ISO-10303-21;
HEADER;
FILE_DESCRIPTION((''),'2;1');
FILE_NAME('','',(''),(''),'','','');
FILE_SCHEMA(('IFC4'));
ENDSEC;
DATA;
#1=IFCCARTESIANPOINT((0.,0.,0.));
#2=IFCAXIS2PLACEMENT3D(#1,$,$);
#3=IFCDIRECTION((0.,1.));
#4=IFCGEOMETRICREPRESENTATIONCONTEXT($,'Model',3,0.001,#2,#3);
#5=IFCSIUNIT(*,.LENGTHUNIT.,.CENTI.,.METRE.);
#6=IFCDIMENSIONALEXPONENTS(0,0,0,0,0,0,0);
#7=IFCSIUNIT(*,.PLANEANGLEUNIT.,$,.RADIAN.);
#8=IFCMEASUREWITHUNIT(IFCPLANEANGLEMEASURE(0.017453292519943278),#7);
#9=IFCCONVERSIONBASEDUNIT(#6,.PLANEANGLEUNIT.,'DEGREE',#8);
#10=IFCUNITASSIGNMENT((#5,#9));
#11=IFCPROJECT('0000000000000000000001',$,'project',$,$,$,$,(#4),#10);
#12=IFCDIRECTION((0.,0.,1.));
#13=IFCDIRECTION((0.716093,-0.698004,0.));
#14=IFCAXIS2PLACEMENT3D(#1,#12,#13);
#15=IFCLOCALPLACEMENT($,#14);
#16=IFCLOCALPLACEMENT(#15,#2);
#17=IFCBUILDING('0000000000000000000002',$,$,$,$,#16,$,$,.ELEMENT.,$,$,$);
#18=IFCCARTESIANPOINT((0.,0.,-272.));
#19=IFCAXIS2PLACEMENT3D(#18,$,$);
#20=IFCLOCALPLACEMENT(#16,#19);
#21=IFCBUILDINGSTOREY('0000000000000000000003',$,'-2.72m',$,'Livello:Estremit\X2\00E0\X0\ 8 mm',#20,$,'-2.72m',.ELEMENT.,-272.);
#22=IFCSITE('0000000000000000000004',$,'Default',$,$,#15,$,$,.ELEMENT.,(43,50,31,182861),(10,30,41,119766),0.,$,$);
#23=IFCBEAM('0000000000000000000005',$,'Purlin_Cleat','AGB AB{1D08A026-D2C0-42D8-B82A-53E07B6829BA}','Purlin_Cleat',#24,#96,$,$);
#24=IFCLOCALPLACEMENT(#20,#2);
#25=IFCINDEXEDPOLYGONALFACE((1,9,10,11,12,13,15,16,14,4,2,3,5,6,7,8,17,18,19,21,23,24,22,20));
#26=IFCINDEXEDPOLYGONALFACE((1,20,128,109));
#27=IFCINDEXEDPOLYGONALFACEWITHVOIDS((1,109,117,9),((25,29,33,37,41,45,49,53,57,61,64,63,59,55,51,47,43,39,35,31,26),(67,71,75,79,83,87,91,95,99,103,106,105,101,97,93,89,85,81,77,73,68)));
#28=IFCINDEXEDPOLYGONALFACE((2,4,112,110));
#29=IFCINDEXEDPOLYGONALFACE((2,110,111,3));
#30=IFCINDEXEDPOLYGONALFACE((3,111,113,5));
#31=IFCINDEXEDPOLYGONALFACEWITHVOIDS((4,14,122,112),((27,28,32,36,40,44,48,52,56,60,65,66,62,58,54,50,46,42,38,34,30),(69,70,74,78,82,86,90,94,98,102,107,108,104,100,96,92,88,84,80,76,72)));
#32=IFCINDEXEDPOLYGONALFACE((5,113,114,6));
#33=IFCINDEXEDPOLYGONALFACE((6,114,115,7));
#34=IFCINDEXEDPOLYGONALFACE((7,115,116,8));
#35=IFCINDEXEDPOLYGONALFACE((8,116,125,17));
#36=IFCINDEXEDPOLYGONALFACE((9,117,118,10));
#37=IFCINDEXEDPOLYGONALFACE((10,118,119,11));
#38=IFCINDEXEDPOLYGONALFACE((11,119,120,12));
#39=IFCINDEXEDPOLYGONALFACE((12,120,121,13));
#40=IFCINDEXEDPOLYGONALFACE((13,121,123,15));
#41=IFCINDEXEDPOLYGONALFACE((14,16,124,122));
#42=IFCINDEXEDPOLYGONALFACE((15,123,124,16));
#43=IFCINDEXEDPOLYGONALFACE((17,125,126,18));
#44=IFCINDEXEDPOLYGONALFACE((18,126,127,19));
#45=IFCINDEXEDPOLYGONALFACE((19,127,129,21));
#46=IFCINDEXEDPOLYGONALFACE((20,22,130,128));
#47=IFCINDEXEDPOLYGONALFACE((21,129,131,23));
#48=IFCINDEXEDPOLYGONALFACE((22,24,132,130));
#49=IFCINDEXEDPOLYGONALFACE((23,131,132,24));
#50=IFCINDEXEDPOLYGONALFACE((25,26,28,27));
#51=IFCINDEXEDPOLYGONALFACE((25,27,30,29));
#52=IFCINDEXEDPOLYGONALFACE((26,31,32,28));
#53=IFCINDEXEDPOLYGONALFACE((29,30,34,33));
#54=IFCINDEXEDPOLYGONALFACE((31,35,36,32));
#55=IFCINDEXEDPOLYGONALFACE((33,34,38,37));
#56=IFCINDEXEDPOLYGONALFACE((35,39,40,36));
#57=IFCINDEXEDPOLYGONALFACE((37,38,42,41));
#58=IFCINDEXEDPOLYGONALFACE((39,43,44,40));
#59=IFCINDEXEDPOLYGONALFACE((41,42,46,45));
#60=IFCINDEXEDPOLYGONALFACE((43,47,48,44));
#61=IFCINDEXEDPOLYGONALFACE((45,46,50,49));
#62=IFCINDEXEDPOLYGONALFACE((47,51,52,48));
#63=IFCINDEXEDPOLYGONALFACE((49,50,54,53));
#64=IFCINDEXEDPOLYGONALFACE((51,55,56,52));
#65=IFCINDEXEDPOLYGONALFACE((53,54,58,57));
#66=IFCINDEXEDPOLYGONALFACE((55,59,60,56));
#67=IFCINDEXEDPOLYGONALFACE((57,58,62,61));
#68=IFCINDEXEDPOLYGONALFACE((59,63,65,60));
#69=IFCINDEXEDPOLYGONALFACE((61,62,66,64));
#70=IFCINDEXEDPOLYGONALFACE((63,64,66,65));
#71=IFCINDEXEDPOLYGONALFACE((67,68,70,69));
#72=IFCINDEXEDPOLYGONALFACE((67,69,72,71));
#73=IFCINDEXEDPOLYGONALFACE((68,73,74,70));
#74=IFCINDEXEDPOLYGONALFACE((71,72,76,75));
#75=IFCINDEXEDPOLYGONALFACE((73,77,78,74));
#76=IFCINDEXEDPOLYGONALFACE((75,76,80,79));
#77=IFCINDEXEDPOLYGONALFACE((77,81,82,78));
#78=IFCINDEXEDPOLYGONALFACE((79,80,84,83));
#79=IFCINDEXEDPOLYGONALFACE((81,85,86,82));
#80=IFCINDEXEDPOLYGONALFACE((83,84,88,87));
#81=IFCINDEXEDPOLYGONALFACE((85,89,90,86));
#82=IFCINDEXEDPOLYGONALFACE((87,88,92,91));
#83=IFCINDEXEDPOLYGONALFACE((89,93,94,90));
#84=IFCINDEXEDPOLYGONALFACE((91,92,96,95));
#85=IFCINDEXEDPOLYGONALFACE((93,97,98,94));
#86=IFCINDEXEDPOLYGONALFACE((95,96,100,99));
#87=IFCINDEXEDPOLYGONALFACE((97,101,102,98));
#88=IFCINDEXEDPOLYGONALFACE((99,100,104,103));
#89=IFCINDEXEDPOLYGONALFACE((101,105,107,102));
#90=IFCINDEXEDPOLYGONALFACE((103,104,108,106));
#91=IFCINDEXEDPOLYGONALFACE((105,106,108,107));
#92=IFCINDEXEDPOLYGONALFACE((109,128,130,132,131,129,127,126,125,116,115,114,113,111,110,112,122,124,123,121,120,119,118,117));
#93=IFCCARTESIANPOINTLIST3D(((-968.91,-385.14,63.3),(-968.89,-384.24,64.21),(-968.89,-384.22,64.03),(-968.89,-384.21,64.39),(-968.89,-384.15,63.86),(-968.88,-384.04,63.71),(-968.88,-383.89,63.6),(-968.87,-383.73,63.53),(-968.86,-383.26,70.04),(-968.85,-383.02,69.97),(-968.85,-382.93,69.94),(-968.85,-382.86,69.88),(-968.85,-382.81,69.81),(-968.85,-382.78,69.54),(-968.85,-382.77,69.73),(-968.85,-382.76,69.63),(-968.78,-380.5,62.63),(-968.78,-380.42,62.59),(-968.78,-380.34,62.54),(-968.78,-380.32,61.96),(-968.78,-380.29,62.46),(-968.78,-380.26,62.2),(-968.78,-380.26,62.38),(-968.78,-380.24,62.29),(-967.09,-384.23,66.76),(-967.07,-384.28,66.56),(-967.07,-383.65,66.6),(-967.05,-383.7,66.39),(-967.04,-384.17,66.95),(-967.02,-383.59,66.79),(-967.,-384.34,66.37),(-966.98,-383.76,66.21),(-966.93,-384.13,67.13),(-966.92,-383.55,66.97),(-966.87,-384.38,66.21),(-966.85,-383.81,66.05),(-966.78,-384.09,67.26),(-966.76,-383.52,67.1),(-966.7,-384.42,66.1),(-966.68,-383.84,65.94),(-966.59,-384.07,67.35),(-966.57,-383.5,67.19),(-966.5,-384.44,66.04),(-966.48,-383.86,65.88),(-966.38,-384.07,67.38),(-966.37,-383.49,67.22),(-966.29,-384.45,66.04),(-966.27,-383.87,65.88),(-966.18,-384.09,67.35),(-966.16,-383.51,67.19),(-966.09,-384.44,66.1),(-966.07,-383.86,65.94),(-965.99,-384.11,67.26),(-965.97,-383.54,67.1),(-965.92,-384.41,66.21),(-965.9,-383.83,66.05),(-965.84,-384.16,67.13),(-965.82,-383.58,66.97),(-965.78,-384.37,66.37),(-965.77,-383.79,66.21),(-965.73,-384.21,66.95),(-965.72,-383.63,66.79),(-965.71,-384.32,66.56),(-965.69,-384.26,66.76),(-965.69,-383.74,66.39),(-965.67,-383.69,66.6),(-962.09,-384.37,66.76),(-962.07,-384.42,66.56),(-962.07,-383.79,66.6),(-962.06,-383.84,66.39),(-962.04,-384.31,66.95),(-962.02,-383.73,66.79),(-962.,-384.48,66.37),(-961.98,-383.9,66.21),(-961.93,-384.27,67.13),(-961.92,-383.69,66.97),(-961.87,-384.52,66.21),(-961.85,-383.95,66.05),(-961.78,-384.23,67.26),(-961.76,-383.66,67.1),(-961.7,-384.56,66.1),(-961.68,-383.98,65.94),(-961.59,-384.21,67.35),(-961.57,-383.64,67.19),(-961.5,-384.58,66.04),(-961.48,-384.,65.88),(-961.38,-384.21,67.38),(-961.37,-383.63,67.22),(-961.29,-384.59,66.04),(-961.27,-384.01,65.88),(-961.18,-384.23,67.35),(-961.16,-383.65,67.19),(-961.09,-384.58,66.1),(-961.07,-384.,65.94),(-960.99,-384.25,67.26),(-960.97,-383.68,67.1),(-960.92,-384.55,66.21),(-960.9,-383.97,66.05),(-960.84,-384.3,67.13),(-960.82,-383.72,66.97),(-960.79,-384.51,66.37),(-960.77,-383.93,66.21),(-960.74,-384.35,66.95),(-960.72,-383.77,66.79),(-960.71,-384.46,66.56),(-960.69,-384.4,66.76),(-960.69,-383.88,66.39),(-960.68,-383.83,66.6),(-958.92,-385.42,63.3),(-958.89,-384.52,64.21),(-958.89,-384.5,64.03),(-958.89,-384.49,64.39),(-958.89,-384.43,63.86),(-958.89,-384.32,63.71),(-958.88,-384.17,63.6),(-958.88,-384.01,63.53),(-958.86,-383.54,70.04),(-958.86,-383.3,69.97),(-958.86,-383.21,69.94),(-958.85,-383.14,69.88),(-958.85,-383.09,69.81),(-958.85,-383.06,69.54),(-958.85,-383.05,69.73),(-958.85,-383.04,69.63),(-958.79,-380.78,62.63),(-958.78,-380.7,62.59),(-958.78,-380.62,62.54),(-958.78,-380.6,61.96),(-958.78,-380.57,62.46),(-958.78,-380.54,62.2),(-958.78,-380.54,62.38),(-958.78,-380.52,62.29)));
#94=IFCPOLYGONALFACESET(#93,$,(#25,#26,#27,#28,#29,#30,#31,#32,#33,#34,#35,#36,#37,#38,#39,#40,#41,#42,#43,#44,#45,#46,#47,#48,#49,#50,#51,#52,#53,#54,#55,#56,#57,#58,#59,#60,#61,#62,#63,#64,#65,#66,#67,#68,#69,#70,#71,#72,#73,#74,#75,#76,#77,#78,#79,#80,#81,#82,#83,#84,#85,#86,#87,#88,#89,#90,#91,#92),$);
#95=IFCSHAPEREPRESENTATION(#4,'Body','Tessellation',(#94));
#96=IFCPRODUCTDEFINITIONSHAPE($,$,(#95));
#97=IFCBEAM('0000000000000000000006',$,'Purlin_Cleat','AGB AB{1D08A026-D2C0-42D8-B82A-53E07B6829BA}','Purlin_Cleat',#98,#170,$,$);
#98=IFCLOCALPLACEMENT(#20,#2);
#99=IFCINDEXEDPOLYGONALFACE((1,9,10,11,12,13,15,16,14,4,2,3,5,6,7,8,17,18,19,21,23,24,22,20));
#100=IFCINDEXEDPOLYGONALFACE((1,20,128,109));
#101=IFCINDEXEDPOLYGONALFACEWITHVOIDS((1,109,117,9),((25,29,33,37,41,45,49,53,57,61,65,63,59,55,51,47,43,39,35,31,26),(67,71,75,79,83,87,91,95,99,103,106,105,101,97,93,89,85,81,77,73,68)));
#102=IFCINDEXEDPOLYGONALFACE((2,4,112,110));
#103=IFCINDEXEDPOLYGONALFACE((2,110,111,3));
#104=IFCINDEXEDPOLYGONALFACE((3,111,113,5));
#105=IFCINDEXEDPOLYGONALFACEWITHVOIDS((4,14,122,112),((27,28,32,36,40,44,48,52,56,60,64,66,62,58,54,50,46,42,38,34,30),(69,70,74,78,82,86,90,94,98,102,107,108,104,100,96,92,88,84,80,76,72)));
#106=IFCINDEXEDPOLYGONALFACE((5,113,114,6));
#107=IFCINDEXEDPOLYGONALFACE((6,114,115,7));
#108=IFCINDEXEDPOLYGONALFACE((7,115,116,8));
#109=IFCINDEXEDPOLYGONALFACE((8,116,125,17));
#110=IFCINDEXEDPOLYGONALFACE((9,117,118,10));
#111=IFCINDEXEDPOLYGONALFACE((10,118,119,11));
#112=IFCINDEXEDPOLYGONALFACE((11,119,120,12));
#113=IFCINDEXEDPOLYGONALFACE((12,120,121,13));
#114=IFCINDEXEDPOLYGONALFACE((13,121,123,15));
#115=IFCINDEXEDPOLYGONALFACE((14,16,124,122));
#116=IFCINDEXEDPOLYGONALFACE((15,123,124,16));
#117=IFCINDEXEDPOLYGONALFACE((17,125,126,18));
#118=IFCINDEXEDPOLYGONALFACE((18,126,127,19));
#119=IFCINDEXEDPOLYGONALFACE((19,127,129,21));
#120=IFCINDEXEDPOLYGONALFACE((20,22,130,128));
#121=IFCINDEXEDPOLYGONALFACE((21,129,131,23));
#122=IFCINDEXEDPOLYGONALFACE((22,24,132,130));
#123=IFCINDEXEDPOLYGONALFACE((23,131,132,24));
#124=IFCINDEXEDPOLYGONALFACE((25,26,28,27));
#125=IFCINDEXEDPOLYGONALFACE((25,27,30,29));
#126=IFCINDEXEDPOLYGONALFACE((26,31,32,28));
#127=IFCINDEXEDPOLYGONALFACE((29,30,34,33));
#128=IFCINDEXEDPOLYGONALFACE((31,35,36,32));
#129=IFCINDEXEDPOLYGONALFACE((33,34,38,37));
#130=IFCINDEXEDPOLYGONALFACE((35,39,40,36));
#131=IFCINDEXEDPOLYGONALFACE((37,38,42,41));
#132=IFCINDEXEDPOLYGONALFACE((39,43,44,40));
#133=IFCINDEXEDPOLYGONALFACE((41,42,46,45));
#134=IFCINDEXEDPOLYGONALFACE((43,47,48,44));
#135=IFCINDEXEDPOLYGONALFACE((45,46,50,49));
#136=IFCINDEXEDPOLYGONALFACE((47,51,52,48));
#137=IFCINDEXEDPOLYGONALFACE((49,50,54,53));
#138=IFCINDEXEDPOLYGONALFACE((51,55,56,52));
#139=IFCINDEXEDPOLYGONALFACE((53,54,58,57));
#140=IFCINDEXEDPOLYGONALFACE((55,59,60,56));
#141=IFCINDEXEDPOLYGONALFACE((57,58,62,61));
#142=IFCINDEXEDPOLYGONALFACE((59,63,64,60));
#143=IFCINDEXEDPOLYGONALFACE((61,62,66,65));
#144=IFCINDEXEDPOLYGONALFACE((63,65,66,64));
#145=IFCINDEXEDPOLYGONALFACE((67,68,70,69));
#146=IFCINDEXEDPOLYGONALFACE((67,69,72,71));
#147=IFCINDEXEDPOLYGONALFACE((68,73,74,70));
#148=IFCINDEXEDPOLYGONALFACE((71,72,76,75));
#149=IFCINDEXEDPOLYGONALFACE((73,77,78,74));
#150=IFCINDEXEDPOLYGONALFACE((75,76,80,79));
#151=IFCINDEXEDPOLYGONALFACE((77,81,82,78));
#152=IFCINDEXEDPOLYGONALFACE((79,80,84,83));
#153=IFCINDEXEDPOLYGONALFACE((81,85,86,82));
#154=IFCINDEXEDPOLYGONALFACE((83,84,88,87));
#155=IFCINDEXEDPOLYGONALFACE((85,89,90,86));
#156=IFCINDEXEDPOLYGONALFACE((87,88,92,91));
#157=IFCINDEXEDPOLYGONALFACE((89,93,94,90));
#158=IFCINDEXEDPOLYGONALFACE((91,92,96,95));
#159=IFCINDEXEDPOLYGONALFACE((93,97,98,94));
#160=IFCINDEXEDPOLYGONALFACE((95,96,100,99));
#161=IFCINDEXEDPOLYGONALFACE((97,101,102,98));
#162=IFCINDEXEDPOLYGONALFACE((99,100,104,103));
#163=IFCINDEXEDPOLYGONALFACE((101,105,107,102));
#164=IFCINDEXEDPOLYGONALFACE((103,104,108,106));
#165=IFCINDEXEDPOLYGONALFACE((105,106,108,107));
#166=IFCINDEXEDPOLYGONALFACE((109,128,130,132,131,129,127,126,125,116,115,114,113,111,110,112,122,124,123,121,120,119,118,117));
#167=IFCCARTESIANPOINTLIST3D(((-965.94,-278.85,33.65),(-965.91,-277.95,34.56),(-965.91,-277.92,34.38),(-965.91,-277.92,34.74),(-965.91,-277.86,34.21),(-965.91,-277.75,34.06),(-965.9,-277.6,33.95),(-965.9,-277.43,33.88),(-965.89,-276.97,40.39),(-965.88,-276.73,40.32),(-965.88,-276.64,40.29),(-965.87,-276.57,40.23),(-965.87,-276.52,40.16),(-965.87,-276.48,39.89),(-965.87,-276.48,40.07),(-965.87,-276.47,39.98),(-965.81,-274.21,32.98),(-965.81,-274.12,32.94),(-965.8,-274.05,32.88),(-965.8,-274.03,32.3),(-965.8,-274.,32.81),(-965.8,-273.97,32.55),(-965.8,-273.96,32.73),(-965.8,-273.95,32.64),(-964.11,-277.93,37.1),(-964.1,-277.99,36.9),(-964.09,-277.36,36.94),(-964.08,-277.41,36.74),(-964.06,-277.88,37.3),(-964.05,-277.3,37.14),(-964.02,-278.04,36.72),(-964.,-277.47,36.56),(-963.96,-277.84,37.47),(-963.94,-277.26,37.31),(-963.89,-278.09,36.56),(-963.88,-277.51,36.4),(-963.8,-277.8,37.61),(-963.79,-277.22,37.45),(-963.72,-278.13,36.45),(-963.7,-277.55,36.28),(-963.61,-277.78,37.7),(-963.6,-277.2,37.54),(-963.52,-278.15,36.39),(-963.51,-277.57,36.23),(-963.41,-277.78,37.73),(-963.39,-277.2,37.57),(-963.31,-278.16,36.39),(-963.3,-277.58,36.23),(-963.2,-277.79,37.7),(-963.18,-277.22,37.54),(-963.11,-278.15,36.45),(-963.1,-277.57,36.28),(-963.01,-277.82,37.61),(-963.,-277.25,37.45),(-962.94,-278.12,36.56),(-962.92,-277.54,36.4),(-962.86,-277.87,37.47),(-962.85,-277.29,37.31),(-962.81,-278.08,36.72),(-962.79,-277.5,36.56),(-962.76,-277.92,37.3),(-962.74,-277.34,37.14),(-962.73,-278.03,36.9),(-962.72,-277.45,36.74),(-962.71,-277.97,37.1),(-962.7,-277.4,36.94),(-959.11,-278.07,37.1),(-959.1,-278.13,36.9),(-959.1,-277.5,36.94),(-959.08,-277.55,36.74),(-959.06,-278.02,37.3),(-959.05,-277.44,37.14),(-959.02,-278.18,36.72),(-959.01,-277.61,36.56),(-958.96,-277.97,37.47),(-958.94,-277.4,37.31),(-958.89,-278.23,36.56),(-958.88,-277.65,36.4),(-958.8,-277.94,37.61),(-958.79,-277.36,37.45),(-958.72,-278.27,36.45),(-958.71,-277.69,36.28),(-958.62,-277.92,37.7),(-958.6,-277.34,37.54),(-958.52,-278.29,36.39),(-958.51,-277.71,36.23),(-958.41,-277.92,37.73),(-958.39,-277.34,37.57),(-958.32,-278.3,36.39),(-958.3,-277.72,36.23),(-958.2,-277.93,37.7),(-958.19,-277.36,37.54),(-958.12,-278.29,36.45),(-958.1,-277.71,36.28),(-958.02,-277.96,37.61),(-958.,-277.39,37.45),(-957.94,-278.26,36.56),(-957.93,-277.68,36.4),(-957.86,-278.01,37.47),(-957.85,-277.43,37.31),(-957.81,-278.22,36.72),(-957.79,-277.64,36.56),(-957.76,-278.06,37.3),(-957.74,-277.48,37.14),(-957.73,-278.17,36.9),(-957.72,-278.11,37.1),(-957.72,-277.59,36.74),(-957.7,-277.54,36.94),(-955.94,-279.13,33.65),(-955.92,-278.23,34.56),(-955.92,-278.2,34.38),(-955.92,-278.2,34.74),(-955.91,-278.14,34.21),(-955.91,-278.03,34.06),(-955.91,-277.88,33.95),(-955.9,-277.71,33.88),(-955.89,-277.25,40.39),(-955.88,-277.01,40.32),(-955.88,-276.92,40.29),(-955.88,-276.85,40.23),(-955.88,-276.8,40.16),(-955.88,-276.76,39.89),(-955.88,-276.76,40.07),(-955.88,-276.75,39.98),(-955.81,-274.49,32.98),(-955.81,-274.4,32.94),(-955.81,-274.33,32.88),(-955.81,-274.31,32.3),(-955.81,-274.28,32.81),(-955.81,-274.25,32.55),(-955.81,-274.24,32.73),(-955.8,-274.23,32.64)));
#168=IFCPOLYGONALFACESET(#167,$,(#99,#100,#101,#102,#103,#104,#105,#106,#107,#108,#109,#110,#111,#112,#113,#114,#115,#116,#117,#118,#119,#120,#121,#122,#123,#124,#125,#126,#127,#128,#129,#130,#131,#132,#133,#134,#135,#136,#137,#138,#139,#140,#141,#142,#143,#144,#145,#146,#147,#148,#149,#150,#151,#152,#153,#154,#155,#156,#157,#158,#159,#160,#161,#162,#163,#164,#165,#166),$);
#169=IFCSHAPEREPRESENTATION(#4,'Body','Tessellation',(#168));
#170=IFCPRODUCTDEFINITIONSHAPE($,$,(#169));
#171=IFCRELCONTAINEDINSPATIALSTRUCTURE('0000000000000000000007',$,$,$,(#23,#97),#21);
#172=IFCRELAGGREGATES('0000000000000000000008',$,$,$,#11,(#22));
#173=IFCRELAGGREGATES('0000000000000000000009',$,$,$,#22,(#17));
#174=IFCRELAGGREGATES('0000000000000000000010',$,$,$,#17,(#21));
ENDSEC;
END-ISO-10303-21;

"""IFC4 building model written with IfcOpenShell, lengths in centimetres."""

from ifc_helpers import new_model, entity, si_unit, converted_unit, direction, frame, frame_2d, origin, place, context, project, spatial, circle, l_section, extrude, element, save


model = new_model("IFC4")

# Units and contexts
model_context = context("Model", 3, precision=0.001, world=origin(), true_north=direction((0.0, 1.0)))
ifc_project = project(units=[si_unit("LENGTHUNIT", "METRE", prefix="CENTI"), converted_unit("PLANEANGLEUNIT", "DEGREE", entity("IfcPlaneAngleMeasure", 0.017453292519943278), si_unit("PLANEANGLEUNIT", "RADIAN"), dimensions=[0, 0, 0, 0, 0, 0, 0])], contexts=[model_context])

# Site, building, storey
site_placement = place(None, frame((0.0, 0.0, 0.0), z_axis=(0.0, 0.0, 1.0), x_axis=(0.716093, -0.698004, 0.0)))
site = spatial("IfcSite", under=ifc_project, at=site_placement, Name="Default", CompositionType="ELEMENT", RefLatitude=(43, 50, 31, 182861), RefLongitude=(10, 30, 41, 119766), RefElevation=0.0)
building_placement = place(site_placement, origin())
building = spatial("IfcBuilding", under=site, at=building_placement, CompositionType="ELEMENT")
storey_placement = place(building_placement, frame((0.0, 0.0, -272.0)))
storey = spatial("IfcBuildingStorey", under=building, at=storey_placement, Name="-2.72m", ObjectType="Livello:Estremità 8 mm", LongName="-2.72m", CompositionType="ELEMENT", Elevation=-272.0)

# Beams, openings
beam_1_placement = place(storey_placement, frame((-958.87, -383.63, 65.14), z_axis=(-0.999608, 0.02798, 0.0), x_axis=(0.007515, 0.268478, 0.963256)))
beam_1 = element("IfcBeam", 1, at=beam_1_placement, inside=storey, Name="Purlin_Cleat", Description="AGB AB{1D08A026-D2C0-42D8-B82A-53E07B6829BA}", ObjectType="Purlin_Cleat", context=model_context, shape_type="SweptSolid", body=[
    extrude(l_section(Depth=5.0, Width=7.0, Thickness=0.6, FilletRadius=0.7, EdgeRadius=0.35, at=frame_2d((1.25, 1.27))), origin(), (0.0, 0.0, 1.0), 10.0),
])
opening_1_placement = place(beam_1_placement, frame((1.29, -1.3, 6.8), z_axis=(0.0, -1.0, 0.0), x_axis=(1.0, 0.0, 0.0)))
element("IfcOpeningElement", 2, at=opening_1_placement, cuts=beam_1, ObjectType="Opening", context=model_context, shape_type="SweptSolid", body=[
    extrude(circle(Radius=0.7, at=frame_2d((0.0, 0.7), x_axis=(1.0, 0.0))), origin(), (0.0, 0.0, -1.0), 0.7),
])
opening_2_placement = place(beam_1_placement, frame((1.29, -1.3, 1.8), z_axis=(0.0, -1.0, 0.0), x_axis=(1.0, 0.0, 0.0)))
element("IfcOpeningElement", 3, at=opening_2_placement, cuts=beam_1, ObjectType="Opening", context=model_context, shape_type="SweptSolid", body=[
    extrude(circle(Radius=0.7, at=frame_2d((0.0, 0.7), x_axis=(1.0, 0.0))), origin(), (0.0, 0.0, -1.0), 0.7),
])
beam_2_placement = place(storey_placement, frame((-955.89, -277.34, 35.48), z_axis=(-0.999608, 0.02798, 0.0), x_axis=(0.007515, 0.268478, 0.963256)))
beam_2 = element("IfcBeam", 4, at=beam_2_placement, inside=storey, Name="Purlin_Cleat", Description="AGB AB{1D08A026-D2C0-42D8-B82A-53E07B6829BA}", ObjectType="Purlin_Cleat", context=model_context, shape_type="SweptSolid", body=[
    extrude(l_section(Depth=5.0, Width=7.0, Thickness=0.6, FilletRadius=0.7, EdgeRadius=0.35, at=frame_2d((1.25, 1.27))), origin(), (0.0, 0.0, 1.0), 10.0),
])
opening_3_placement = place(beam_2_placement, frame((1.29, -1.3, 6.8), z_axis=(0.0, -1.0, 0.0), x_axis=(1.0, 0.0, 0.0)))
element("IfcOpeningElement", 5, at=opening_3_placement, cuts=beam_2, ObjectType="Opening", context=model_context, shape_type="SweptSolid", body=[
    extrude(circle(Radius=0.7, at=frame_2d((0.0, 0.7), x_axis=(1.0, 0.0))), origin(), (0.0, 0.0, -1.0), 0.7),
])
opening_4_placement = place(beam_2_placement, frame((1.29, -1.3, 1.8), z_axis=(0.0, -1.0, 0.0), x_axis=(1.0, 0.0, 0.0)))
element("IfcOpeningElement", 6, at=opening_4_placement, cuts=beam_2, ObjectType="Opening", context=model_context, shape_type="SweptSolid", body=[
    extrude(circle(Radius=0.7, at=frame_2d((0.0, 0.7), x_axis=(1.0, 0.0))), origin(), (0.0, 0.0, -1.0), 0.7),
])

save(model, "model.ifc")
